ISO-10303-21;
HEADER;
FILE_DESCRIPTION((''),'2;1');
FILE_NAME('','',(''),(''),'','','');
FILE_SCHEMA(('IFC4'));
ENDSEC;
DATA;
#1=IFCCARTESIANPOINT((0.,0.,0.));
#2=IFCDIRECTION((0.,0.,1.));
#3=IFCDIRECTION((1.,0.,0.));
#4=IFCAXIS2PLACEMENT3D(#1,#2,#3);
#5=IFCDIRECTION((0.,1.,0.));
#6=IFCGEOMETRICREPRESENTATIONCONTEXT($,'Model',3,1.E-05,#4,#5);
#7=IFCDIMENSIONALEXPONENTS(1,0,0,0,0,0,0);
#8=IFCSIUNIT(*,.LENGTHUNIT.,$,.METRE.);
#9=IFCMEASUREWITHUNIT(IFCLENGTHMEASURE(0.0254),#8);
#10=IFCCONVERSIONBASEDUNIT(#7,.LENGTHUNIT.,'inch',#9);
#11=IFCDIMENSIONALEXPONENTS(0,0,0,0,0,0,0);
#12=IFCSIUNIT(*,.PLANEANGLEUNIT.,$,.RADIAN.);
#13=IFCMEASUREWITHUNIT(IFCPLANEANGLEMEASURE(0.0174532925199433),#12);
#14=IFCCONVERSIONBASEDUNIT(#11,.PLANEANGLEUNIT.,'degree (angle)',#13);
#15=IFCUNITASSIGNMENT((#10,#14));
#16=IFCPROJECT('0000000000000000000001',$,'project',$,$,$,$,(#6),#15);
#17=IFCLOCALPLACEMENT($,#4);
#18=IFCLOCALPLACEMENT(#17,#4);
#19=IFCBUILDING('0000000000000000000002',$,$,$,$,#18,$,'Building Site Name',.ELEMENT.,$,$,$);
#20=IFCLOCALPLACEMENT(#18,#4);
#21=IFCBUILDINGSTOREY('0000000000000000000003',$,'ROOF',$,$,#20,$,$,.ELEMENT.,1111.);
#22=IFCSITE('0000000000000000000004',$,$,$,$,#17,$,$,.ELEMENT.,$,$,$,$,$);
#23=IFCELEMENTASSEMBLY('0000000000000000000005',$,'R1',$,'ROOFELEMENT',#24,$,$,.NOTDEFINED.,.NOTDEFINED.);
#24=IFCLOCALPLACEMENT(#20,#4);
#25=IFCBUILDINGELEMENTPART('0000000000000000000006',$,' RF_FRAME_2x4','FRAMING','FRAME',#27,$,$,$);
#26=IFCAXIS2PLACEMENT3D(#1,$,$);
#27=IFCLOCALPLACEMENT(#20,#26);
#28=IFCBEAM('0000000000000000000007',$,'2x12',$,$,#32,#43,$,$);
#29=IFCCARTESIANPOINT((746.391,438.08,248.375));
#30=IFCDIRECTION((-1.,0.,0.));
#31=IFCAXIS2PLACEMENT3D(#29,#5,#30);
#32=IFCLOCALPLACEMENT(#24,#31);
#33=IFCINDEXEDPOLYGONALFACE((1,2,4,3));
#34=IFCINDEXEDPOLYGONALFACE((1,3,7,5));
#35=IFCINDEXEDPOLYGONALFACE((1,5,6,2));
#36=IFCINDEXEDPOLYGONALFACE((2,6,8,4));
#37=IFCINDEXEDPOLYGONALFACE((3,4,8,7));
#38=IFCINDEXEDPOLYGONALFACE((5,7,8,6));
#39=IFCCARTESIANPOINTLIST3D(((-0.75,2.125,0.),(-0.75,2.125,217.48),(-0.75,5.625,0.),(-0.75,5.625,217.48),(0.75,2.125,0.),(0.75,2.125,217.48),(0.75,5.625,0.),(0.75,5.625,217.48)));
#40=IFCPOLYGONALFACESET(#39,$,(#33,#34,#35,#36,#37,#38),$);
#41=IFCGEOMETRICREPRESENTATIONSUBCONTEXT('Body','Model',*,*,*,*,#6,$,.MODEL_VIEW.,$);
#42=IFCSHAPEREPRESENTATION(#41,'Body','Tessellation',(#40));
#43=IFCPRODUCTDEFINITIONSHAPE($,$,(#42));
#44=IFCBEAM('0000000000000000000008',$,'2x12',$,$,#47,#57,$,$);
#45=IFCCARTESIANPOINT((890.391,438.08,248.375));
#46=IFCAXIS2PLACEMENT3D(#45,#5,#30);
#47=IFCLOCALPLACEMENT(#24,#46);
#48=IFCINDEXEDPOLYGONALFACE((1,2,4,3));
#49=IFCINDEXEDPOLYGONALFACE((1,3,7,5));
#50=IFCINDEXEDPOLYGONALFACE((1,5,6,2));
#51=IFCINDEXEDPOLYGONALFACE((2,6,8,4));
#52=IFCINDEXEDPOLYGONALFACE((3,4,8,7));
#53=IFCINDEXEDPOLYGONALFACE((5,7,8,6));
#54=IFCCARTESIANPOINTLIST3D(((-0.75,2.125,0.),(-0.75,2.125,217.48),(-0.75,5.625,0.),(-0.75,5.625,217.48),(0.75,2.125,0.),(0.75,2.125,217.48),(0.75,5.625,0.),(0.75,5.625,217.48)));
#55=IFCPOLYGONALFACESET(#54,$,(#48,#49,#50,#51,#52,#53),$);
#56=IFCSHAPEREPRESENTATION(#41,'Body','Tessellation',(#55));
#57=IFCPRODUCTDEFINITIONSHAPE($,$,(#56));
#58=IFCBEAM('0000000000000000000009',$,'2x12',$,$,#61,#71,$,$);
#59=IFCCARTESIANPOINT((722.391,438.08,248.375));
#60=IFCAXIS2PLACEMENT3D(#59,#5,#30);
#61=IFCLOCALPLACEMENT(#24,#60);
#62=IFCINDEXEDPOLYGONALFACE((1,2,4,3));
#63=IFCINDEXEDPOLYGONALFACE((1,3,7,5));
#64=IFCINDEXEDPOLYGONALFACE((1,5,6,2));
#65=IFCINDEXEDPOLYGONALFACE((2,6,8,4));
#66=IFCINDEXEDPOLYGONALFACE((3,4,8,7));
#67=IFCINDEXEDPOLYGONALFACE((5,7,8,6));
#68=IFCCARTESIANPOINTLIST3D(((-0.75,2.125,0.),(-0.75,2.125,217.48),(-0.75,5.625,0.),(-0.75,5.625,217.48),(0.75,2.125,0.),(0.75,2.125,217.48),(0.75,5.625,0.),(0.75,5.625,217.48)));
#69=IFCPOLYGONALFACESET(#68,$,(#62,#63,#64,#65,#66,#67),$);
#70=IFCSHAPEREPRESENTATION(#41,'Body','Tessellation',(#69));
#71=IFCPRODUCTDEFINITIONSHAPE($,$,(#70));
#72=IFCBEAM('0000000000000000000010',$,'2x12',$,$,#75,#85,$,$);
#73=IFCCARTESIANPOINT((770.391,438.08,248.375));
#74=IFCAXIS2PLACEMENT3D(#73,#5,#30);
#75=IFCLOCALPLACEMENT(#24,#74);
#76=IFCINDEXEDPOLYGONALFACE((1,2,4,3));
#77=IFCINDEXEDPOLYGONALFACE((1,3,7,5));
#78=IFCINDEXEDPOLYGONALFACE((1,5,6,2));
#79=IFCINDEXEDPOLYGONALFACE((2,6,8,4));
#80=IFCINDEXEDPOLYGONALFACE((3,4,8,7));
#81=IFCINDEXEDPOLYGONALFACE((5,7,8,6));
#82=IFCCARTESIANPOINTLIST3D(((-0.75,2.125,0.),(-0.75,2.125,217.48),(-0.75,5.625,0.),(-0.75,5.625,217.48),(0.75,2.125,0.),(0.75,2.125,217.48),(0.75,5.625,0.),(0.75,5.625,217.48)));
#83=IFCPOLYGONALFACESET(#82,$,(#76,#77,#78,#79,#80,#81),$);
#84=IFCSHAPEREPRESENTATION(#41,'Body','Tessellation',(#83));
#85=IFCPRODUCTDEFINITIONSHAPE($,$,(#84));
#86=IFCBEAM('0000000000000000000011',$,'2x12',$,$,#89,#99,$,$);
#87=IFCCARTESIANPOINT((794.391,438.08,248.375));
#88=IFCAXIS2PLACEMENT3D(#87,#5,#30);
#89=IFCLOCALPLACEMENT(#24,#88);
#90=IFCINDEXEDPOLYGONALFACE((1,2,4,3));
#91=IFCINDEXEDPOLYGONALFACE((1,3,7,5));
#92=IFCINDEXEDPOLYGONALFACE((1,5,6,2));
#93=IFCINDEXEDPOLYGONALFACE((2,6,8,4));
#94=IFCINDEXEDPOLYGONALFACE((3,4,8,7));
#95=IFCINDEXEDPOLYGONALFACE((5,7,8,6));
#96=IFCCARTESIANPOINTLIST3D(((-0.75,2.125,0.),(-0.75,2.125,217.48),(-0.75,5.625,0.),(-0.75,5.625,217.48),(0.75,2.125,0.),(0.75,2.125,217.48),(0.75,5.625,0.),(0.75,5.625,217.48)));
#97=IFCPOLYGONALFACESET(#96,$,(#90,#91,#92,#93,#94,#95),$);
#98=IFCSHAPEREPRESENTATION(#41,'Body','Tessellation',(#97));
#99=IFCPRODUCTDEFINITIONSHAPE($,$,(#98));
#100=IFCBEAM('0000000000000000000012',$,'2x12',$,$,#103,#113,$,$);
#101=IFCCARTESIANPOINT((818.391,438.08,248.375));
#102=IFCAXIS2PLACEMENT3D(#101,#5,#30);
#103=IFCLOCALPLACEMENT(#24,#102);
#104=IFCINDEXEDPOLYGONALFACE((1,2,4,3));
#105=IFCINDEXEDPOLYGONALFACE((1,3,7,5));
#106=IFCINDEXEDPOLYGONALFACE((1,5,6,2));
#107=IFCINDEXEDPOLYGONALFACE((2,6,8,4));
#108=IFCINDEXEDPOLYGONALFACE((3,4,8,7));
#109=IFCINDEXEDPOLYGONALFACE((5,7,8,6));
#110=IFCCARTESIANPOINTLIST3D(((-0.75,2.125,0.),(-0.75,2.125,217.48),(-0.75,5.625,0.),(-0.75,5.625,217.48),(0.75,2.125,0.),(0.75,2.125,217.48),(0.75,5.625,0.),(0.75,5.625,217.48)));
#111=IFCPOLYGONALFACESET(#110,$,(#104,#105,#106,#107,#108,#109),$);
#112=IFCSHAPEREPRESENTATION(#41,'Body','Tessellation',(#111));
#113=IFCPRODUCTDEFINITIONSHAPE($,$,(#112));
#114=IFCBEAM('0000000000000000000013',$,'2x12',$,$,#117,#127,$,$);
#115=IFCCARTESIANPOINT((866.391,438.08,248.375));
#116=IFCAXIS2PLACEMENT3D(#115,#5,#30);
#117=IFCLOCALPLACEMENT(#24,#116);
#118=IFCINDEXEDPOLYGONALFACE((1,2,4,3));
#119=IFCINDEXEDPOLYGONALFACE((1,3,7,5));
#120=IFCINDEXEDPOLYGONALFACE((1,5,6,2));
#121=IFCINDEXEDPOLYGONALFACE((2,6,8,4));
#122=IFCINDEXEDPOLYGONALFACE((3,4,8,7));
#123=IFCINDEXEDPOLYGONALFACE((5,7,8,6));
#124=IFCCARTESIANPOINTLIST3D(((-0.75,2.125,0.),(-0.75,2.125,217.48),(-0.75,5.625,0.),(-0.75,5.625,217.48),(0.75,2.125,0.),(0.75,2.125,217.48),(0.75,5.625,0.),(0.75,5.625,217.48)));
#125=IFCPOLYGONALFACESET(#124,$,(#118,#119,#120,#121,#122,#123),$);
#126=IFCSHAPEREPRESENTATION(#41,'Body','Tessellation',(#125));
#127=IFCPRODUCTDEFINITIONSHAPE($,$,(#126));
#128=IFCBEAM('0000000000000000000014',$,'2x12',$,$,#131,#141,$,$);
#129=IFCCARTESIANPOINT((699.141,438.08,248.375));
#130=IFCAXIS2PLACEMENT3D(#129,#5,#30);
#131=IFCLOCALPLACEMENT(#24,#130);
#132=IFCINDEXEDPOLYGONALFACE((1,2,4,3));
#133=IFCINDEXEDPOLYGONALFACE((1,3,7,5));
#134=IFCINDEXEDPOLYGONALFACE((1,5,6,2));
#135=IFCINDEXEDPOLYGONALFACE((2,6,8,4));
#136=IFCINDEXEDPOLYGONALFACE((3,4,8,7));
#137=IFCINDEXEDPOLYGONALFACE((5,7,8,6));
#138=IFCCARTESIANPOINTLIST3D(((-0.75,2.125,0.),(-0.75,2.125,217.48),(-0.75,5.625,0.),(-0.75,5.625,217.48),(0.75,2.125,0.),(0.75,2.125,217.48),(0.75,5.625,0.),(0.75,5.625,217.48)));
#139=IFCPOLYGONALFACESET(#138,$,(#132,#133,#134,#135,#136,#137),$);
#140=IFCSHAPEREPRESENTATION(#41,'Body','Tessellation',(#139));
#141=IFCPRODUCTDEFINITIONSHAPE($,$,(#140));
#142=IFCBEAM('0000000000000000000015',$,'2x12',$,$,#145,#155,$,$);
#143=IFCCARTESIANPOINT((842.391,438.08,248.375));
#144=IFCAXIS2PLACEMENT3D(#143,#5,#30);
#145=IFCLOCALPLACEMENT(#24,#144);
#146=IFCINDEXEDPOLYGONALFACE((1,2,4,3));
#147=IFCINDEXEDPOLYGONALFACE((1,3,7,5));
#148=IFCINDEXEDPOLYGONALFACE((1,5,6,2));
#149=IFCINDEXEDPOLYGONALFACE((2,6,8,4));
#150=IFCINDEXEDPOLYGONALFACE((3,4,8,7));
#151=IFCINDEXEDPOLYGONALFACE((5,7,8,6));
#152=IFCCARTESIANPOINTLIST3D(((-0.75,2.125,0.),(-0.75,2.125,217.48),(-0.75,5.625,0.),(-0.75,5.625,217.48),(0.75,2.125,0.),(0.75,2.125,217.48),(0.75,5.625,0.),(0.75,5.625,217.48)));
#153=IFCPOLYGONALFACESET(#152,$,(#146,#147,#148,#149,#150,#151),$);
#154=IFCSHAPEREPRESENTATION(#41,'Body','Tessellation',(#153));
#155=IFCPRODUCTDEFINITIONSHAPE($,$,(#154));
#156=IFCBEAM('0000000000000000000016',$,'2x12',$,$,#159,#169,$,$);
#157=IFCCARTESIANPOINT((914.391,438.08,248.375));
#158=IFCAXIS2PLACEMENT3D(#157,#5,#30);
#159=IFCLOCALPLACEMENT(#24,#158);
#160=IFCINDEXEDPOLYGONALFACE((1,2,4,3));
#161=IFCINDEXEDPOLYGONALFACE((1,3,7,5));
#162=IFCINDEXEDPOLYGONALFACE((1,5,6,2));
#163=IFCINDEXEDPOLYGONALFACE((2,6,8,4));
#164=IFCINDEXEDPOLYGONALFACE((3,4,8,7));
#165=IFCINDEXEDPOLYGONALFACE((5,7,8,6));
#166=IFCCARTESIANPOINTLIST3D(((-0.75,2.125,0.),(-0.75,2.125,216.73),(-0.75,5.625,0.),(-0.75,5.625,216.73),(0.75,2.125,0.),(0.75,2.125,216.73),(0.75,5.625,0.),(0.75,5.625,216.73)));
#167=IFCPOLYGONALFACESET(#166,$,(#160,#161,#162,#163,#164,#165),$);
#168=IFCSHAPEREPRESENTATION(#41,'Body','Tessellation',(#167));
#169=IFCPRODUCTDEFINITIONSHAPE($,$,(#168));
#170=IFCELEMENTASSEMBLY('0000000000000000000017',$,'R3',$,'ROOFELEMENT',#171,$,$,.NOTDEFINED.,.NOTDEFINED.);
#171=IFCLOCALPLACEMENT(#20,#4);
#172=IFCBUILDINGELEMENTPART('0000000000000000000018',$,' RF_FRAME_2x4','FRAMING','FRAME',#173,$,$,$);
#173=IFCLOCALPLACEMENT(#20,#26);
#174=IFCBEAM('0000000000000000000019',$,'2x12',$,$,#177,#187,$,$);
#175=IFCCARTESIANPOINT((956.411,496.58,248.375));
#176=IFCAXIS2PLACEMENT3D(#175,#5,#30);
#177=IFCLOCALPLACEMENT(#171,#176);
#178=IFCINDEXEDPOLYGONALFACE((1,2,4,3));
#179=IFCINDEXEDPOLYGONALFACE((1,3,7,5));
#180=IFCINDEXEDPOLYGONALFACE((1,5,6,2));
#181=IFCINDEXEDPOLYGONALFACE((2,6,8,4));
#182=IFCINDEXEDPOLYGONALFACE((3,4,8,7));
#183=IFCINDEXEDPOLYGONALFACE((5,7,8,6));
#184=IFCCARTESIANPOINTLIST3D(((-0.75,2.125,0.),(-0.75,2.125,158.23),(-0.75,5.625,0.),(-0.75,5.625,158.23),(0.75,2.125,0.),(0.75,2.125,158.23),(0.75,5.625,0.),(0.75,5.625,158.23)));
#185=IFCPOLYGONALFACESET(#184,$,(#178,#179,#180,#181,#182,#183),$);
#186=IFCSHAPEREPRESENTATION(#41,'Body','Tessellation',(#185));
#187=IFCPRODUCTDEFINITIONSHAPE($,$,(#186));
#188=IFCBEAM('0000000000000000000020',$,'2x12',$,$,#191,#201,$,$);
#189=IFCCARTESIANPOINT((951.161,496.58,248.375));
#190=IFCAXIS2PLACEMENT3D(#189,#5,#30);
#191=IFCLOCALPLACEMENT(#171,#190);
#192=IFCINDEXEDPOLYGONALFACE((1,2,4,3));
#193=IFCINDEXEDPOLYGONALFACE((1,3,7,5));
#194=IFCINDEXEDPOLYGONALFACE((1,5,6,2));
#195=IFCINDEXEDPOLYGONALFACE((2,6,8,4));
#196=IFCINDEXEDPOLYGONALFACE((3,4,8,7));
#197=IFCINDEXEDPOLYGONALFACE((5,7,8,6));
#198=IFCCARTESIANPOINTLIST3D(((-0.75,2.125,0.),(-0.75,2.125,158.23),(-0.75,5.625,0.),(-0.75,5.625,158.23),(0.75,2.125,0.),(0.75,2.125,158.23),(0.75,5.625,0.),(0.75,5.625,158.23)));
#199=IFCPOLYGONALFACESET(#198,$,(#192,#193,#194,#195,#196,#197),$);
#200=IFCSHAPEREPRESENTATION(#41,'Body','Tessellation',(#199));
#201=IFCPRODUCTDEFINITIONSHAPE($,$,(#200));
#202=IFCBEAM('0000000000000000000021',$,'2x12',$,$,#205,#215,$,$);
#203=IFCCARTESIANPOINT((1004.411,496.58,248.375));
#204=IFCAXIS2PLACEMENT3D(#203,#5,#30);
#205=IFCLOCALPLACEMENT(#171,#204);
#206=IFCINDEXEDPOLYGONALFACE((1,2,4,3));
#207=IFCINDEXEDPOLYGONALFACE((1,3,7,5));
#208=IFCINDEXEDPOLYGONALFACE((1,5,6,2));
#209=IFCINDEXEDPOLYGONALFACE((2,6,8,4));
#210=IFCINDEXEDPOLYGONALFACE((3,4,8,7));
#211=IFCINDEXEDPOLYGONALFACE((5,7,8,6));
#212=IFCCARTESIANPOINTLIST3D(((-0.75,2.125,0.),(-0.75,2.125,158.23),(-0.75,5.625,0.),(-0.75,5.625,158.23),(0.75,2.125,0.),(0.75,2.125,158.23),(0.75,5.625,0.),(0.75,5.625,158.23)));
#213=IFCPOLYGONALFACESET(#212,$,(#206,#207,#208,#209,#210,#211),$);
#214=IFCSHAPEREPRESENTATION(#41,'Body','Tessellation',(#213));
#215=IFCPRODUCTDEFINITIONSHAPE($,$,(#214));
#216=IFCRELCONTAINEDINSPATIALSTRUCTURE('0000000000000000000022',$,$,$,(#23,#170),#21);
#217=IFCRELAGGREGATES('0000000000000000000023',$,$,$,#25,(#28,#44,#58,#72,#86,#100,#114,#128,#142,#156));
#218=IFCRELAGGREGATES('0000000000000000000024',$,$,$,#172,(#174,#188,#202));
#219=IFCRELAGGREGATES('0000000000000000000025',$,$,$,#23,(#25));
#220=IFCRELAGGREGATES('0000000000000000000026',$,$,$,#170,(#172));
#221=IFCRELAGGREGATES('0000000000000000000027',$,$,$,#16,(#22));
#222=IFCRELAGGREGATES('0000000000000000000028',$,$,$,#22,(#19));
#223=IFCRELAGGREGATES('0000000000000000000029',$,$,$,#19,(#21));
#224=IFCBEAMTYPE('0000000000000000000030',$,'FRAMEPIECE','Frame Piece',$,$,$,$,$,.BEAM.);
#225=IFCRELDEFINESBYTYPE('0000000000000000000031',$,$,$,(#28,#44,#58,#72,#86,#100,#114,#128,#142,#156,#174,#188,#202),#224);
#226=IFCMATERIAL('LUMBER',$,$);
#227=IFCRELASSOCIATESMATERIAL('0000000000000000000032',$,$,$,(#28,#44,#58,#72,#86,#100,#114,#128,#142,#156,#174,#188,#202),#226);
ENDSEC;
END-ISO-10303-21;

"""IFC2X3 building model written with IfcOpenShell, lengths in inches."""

from ifc_helpers import new_model, entity, si_unit, converted_unit, direction, frame, frame_2d, origin_with_axes, place, context, subcontext, project, spatial, rectangle, extrude, material, type_object, element, aggregate, save


model = new_model("IFC2X3")

# Units and contexts
model_context = context("Model", 3, precision=1e-05, world=origin_with_axes(), true_north=direction((0.0, 1.0, 0.0)))
body_context = subcontext(model_context, "Body", "Model", "MODEL_VIEW")
ifc_project = project(units=[converted_unit("LENGTHUNIT", "inch", entity("IfcLengthMeasure", 0.0254), si_unit("LENGTHUNIT", "METRE"), dimensions=[1, 0, 0, 0, 0, 0, 0]), converted_unit("PLANEANGLEUNIT", "degree (angle)", entity("IfcPlaneAngleMeasure", 0.0174532925199433), si_unit("PLANEANGLEUNIT", "RADIAN"), dimensions=[0, 0, 0, 0, 0, 0, 0])], contexts=[model_context])

# Site, building, storey
site_placement = place(None, origin_with_axes())
site = spatial("IfcSite", under=ifc_project, at=site_placement, CompositionType="ELEMENT")
building_placement = place(site_placement, origin_with_axes())
building = spatial("IfcBuilding", under=site, at=building_placement, LongName="Building Site Name", CompositionType="ELEMENT")
storey_placement = place(building_placement, origin_with_axes())
storey = spatial("IfcBuildingStorey", under=building, at=storey_placement, Name="ROOF", CompositionType="ELEMENT", Elevation=1111.0)

# Element assemblies, building element parts, beams
assembly_1_placement = place(storey_placement, origin_with_axes())
assembly_1 = element("IfcElementAssembly", 1, at=assembly_1_placement, inside=storey, Name="R1", ObjectType="ROOFELEMENT", AssemblyPlace="NOTDEFINED", PredefinedType="NOTDEFINED")
building_element_part_1 = element("IfcBuildingElementPart", 2, Name=" RF_FRAME_2x4", Description="FRAMING", ObjectType="FRAME")
ifc_material_1 = material(Name="LUMBER")
beam_type = type_object("IfcBeamType", Name="FRAMEPIECE", Description="Frame Piece", PredefinedType="BEAM")
beam_1_placement = place(assembly_1_placement, frame((746.391, 438.08, 248.375), z_axis=(0.0, 1.0, 0.0), x_axis=(-1.0, 0.0, 0.0)))
beam_1 = element("IfcBeam", 3, at=beam_1_placement, type_object=beam_type, material=ifc_material_1, Name="2x12", context=body_context, shape_type="SweptSolid", body=[
    extrude(rectangle(XDim=3.5, YDim=1.5, at=frame_2d((0.0, 3.875), x_axis=(0.0, -1.0))), frame((0.0, 0.0, 0.0), z_axis=(0.0, 0.0, 1.0), x_axis=(1.0, 0.0, 0.0)), (0.0, 0.0, 1.0), 217.48),
])
beam_2_placement = place(assembly_1_placement, frame((890.391, 438.08, 248.375), z_axis=(0.0, 1.0, 0.0), x_axis=(-1.0, 0.0, 0.0)))
beam_2 = element("IfcBeam", 4, at=beam_2_placement, type_object=beam_type, material=ifc_material_1, Name="2x12", context=body_context, shape_type="SweptSolid", body=[
    extrude(rectangle(XDim=3.5, YDim=1.5, at=frame_2d((0.0, 3.875), x_axis=(0.0, -1.0))), origin_with_axes(), (0.0, 0.0, 1.0), 217.48),
])
beam_3_placement = place(assembly_1_placement, frame((722.391, 438.08, 248.375), z_axis=(0.0, 1.0, 0.0), x_axis=(-1.0, 0.0, 0.0)))
beam_3 = element("IfcBeam", 5, at=beam_3_placement, type_object=beam_type, material=ifc_material_1, Name="2x12", context=body_context, shape_type="SweptSolid", body=[
    extrude(rectangle(XDim=3.5, YDim=1.5, at=frame_2d((0.0, 3.875), x_axis=(0.0, -1.0))), frame((0.0, 0.0, 0.0), z_axis=(0.0, 0.0, 1.0), x_axis=(1.0, 0.0, 0.0)), (0.0, 0.0, 1.0), 217.48),
])
beam_4_placement = place(assembly_1_placement, frame((770.391, 438.08, 248.375), z_axis=(0.0, 1.0, 0.0), x_axis=(-1.0, 0.0, 0.0)))
beam_4 = element("IfcBeam", 6, at=beam_4_placement, type_object=beam_type, material=ifc_material_1, Name="2x12", context=body_context, shape_type="SweptSolid", body=[
    extrude(rectangle(XDim=3.5, YDim=1.5, at=frame_2d((0.0, 3.875), x_axis=(0.0, -1.0))), frame((0.0, 0.0, 0.0), z_axis=(0.0, 0.0, 1.0), x_axis=(1.0, 0.0, 0.0)), (0.0, 0.0, 1.0), 217.48),
])
beam_5_placement = place(assembly_1_placement, frame((794.391, 438.08, 248.375), z_axis=(0.0, 1.0, 0.0), x_axis=(-1.0, 0.0, 0.0)))
beam_5 = element("IfcBeam", 7, at=beam_5_placement, type_object=beam_type, material=ifc_material_1, Name="2x12", context=body_context, shape_type="SweptSolid", body=[
    extrude(rectangle(XDim=3.5, YDim=1.5, at=frame_2d((0.0, 3.875), x_axis=(0.0, -1.0))), origin_with_axes(), (0.0, 0.0, 1.0), 217.48),
])
beam_6_placement = place(assembly_1_placement, frame((818.391, 438.08, 248.375), z_axis=(0.0, 1.0, 0.0), x_axis=(-1.0, 0.0, 0.0)))
beam_6 = element("IfcBeam", 8, at=beam_6_placement, type_object=beam_type, material=ifc_material_1, Name="2x12", context=body_context, shape_type="SweptSolid", body=[
    extrude(rectangle(XDim=3.5, YDim=1.5, at=frame_2d((0.0, 3.875), x_axis=(0.0, -1.0))), origin_with_axes(), (0.0, 0.0, 1.0), 217.48),
])
beam_7_placement = place(assembly_1_placement, frame((866.391, 438.08, 248.375), z_axis=(0.0, 1.0, 0.0), x_axis=(-1.0, 0.0, 0.0)))
beam_7 = element("IfcBeam", 9, at=beam_7_placement, type_object=beam_type, material=ifc_material_1, Name="2x12", context=body_context, shape_type="SweptSolid", body=[
    extrude(rectangle(XDim=3.5, YDim=1.5, at=frame_2d((0.0, 3.875), x_axis=(0.0, -1.0))), origin_with_axes(), (0.0, 0.0, 1.0), 217.48),
])
beam_8_placement = place(assembly_1_placement, frame((699.141, 438.08, 248.375), z_axis=(0.0, 1.0, 0.0), x_axis=(-1.0, 0.0, 0.0)))
beam_8 = element("IfcBeam", 10, at=beam_8_placement, type_object=beam_type, material=ifc_material_1, Name="2x12", context=body_context, shape_type="SweptSolid", body=[
    extrude(rectangle(XDim=3.5, YDim=1.5, at=frame_2d((0.0, 3.875), x_axis=(0.0, -1.0))), origin_with_axes(), (0.0, 0.0, 1.0), 217.48),
])
beam_9_placement = place(assembly_1_placement, frame((842.391, 438.08, 248.375), z_axis=(0.0, 1.0, 0.0), x_axis=(-1.0, 0.0, 0.0)))
beam_9 = element("IfcBeam", 11, at=beam_9_placement, type_object=beam_type, material=ifc_material_1, Name="2x12", context=body_context, shape_type="SweptSolid", body=[
    extrude(rectangle(XDim=3.5, YDim=1.5, at=frame_2d((0.0, 3.875), x_axis=(0.0, -1.0))), origin_with_axes(), (0.0, 0.0, 1.0), 217.48),
])
beam_10_placement = place(assembly_1_placement, frame((914.391, 438.08, 248.375), z_axis=(0.0, 1.0, 0.0), x_axis=(-1.0, 0.0, 0.0)))
beam_10 = element("IfcBeam", 12, at=beam_10_placement, type_object=beam_type, material=ifc_material_1, Name="2x12", context=body_context, shape_type="SweptSolid", body=[
    extrude(rectangle(XDim=3.5, YDim=1.5, at=frame_2d((0.0, 3.875), x_axis=(0.0, -1.0))), origin_with_axes(), (0.0, 0.0, 1.0), 216.73),
])
aggregate(building_element_part_1, [beam_1, beam_2, beam_3, beam_4, beam_5, beam_6, beam_7, beam_8, beam_9, beam_10])
assembly_2_placement = place(storey_placement, origin_with_axes())
assembly_2 = element("IfcElementAssembly", 13, at=assembly_2_placement, inside=storey, Name="R3", ObjectType="ROOFELEMENT", AssemblyPlace="NOTDEFINED", PredefinedType="NOTDEFINED")
building_element_part_2 = element("IfcBuildingElementPart", 14, Name=" RF_FRAME_2x4", Description="FRAMING", ObjectType="FRAME")
beam_11_placement = place(assembly_2_placement, frame((956.411, 496.58, 248.375), z_axis=(0.0, 1.0, 0.0), x_axis=(-1.0, 0.0, 0.0)))
beam_11 = element("IfcBeam", 15, at=beam_11_placement, type_object=beam_type, material=ifc_material_1, Name="2x12", context=body_context, shape_type="SweptSolid", body=[
    extrude(rectangle(XDim=3.5, YDim=1.5, at=frame_2d((0.0, 3.875), x_axis=(0.0, -1.0))), origin_with_axes(), (0.0, 0.0, 1.0), 158.23),
])
beam_12_placement = place(assembly_2_placement, frame((951.161, 496.58, 248.375), z_axis=(0.0, 1.0, 0.0), x_axis=(-1.0, 0.0, 0.0)))
beam_12 = element("IfcBeam", 16, at=beam_12_placement, type_object=beam_type, material=ifc_material_1, Name="2x12", context=body_context, shape_type="SweptSolid", body=[
    extrude(rectangle(XDim=3.5, YDim=1.5, at=frame_2d((0.0, 3.875), x_axis=(0.0, -1.0))), origin_with_axes(), (0.0, 0.0, 1.0), 158.23),
])
beam_13_placement = place(assembly_2_placement, frame((1004.411, 496.58, 248.375), z_axis=(0.0, 1.0, 0.0), x_axis=(-1.0, 0.0, 0.0)))
beam_13 = element("IfcBeam", 17, at=beam_13_placement, type_object=beam_type, material=ifc_material_1, Name="2x12", context=body_context, shape_type="SweptSolid", body=[
    extrude(rectangle(XDim=3.5, YDim=1.5, at=frame_2d((0.0, 3.875), x_axis=(0.0, -1.0))), origin_with_axes(), (0.0, 0.0, 1.0), 158.23),
])
aggregate(building_element_part_2, [beam_11, beam_12, beam_13])

aggregate(assembly_1, [building_element_part_1])

aggregate(assembly_2, [building_element_part_2])

save(model, "model.ifc")
